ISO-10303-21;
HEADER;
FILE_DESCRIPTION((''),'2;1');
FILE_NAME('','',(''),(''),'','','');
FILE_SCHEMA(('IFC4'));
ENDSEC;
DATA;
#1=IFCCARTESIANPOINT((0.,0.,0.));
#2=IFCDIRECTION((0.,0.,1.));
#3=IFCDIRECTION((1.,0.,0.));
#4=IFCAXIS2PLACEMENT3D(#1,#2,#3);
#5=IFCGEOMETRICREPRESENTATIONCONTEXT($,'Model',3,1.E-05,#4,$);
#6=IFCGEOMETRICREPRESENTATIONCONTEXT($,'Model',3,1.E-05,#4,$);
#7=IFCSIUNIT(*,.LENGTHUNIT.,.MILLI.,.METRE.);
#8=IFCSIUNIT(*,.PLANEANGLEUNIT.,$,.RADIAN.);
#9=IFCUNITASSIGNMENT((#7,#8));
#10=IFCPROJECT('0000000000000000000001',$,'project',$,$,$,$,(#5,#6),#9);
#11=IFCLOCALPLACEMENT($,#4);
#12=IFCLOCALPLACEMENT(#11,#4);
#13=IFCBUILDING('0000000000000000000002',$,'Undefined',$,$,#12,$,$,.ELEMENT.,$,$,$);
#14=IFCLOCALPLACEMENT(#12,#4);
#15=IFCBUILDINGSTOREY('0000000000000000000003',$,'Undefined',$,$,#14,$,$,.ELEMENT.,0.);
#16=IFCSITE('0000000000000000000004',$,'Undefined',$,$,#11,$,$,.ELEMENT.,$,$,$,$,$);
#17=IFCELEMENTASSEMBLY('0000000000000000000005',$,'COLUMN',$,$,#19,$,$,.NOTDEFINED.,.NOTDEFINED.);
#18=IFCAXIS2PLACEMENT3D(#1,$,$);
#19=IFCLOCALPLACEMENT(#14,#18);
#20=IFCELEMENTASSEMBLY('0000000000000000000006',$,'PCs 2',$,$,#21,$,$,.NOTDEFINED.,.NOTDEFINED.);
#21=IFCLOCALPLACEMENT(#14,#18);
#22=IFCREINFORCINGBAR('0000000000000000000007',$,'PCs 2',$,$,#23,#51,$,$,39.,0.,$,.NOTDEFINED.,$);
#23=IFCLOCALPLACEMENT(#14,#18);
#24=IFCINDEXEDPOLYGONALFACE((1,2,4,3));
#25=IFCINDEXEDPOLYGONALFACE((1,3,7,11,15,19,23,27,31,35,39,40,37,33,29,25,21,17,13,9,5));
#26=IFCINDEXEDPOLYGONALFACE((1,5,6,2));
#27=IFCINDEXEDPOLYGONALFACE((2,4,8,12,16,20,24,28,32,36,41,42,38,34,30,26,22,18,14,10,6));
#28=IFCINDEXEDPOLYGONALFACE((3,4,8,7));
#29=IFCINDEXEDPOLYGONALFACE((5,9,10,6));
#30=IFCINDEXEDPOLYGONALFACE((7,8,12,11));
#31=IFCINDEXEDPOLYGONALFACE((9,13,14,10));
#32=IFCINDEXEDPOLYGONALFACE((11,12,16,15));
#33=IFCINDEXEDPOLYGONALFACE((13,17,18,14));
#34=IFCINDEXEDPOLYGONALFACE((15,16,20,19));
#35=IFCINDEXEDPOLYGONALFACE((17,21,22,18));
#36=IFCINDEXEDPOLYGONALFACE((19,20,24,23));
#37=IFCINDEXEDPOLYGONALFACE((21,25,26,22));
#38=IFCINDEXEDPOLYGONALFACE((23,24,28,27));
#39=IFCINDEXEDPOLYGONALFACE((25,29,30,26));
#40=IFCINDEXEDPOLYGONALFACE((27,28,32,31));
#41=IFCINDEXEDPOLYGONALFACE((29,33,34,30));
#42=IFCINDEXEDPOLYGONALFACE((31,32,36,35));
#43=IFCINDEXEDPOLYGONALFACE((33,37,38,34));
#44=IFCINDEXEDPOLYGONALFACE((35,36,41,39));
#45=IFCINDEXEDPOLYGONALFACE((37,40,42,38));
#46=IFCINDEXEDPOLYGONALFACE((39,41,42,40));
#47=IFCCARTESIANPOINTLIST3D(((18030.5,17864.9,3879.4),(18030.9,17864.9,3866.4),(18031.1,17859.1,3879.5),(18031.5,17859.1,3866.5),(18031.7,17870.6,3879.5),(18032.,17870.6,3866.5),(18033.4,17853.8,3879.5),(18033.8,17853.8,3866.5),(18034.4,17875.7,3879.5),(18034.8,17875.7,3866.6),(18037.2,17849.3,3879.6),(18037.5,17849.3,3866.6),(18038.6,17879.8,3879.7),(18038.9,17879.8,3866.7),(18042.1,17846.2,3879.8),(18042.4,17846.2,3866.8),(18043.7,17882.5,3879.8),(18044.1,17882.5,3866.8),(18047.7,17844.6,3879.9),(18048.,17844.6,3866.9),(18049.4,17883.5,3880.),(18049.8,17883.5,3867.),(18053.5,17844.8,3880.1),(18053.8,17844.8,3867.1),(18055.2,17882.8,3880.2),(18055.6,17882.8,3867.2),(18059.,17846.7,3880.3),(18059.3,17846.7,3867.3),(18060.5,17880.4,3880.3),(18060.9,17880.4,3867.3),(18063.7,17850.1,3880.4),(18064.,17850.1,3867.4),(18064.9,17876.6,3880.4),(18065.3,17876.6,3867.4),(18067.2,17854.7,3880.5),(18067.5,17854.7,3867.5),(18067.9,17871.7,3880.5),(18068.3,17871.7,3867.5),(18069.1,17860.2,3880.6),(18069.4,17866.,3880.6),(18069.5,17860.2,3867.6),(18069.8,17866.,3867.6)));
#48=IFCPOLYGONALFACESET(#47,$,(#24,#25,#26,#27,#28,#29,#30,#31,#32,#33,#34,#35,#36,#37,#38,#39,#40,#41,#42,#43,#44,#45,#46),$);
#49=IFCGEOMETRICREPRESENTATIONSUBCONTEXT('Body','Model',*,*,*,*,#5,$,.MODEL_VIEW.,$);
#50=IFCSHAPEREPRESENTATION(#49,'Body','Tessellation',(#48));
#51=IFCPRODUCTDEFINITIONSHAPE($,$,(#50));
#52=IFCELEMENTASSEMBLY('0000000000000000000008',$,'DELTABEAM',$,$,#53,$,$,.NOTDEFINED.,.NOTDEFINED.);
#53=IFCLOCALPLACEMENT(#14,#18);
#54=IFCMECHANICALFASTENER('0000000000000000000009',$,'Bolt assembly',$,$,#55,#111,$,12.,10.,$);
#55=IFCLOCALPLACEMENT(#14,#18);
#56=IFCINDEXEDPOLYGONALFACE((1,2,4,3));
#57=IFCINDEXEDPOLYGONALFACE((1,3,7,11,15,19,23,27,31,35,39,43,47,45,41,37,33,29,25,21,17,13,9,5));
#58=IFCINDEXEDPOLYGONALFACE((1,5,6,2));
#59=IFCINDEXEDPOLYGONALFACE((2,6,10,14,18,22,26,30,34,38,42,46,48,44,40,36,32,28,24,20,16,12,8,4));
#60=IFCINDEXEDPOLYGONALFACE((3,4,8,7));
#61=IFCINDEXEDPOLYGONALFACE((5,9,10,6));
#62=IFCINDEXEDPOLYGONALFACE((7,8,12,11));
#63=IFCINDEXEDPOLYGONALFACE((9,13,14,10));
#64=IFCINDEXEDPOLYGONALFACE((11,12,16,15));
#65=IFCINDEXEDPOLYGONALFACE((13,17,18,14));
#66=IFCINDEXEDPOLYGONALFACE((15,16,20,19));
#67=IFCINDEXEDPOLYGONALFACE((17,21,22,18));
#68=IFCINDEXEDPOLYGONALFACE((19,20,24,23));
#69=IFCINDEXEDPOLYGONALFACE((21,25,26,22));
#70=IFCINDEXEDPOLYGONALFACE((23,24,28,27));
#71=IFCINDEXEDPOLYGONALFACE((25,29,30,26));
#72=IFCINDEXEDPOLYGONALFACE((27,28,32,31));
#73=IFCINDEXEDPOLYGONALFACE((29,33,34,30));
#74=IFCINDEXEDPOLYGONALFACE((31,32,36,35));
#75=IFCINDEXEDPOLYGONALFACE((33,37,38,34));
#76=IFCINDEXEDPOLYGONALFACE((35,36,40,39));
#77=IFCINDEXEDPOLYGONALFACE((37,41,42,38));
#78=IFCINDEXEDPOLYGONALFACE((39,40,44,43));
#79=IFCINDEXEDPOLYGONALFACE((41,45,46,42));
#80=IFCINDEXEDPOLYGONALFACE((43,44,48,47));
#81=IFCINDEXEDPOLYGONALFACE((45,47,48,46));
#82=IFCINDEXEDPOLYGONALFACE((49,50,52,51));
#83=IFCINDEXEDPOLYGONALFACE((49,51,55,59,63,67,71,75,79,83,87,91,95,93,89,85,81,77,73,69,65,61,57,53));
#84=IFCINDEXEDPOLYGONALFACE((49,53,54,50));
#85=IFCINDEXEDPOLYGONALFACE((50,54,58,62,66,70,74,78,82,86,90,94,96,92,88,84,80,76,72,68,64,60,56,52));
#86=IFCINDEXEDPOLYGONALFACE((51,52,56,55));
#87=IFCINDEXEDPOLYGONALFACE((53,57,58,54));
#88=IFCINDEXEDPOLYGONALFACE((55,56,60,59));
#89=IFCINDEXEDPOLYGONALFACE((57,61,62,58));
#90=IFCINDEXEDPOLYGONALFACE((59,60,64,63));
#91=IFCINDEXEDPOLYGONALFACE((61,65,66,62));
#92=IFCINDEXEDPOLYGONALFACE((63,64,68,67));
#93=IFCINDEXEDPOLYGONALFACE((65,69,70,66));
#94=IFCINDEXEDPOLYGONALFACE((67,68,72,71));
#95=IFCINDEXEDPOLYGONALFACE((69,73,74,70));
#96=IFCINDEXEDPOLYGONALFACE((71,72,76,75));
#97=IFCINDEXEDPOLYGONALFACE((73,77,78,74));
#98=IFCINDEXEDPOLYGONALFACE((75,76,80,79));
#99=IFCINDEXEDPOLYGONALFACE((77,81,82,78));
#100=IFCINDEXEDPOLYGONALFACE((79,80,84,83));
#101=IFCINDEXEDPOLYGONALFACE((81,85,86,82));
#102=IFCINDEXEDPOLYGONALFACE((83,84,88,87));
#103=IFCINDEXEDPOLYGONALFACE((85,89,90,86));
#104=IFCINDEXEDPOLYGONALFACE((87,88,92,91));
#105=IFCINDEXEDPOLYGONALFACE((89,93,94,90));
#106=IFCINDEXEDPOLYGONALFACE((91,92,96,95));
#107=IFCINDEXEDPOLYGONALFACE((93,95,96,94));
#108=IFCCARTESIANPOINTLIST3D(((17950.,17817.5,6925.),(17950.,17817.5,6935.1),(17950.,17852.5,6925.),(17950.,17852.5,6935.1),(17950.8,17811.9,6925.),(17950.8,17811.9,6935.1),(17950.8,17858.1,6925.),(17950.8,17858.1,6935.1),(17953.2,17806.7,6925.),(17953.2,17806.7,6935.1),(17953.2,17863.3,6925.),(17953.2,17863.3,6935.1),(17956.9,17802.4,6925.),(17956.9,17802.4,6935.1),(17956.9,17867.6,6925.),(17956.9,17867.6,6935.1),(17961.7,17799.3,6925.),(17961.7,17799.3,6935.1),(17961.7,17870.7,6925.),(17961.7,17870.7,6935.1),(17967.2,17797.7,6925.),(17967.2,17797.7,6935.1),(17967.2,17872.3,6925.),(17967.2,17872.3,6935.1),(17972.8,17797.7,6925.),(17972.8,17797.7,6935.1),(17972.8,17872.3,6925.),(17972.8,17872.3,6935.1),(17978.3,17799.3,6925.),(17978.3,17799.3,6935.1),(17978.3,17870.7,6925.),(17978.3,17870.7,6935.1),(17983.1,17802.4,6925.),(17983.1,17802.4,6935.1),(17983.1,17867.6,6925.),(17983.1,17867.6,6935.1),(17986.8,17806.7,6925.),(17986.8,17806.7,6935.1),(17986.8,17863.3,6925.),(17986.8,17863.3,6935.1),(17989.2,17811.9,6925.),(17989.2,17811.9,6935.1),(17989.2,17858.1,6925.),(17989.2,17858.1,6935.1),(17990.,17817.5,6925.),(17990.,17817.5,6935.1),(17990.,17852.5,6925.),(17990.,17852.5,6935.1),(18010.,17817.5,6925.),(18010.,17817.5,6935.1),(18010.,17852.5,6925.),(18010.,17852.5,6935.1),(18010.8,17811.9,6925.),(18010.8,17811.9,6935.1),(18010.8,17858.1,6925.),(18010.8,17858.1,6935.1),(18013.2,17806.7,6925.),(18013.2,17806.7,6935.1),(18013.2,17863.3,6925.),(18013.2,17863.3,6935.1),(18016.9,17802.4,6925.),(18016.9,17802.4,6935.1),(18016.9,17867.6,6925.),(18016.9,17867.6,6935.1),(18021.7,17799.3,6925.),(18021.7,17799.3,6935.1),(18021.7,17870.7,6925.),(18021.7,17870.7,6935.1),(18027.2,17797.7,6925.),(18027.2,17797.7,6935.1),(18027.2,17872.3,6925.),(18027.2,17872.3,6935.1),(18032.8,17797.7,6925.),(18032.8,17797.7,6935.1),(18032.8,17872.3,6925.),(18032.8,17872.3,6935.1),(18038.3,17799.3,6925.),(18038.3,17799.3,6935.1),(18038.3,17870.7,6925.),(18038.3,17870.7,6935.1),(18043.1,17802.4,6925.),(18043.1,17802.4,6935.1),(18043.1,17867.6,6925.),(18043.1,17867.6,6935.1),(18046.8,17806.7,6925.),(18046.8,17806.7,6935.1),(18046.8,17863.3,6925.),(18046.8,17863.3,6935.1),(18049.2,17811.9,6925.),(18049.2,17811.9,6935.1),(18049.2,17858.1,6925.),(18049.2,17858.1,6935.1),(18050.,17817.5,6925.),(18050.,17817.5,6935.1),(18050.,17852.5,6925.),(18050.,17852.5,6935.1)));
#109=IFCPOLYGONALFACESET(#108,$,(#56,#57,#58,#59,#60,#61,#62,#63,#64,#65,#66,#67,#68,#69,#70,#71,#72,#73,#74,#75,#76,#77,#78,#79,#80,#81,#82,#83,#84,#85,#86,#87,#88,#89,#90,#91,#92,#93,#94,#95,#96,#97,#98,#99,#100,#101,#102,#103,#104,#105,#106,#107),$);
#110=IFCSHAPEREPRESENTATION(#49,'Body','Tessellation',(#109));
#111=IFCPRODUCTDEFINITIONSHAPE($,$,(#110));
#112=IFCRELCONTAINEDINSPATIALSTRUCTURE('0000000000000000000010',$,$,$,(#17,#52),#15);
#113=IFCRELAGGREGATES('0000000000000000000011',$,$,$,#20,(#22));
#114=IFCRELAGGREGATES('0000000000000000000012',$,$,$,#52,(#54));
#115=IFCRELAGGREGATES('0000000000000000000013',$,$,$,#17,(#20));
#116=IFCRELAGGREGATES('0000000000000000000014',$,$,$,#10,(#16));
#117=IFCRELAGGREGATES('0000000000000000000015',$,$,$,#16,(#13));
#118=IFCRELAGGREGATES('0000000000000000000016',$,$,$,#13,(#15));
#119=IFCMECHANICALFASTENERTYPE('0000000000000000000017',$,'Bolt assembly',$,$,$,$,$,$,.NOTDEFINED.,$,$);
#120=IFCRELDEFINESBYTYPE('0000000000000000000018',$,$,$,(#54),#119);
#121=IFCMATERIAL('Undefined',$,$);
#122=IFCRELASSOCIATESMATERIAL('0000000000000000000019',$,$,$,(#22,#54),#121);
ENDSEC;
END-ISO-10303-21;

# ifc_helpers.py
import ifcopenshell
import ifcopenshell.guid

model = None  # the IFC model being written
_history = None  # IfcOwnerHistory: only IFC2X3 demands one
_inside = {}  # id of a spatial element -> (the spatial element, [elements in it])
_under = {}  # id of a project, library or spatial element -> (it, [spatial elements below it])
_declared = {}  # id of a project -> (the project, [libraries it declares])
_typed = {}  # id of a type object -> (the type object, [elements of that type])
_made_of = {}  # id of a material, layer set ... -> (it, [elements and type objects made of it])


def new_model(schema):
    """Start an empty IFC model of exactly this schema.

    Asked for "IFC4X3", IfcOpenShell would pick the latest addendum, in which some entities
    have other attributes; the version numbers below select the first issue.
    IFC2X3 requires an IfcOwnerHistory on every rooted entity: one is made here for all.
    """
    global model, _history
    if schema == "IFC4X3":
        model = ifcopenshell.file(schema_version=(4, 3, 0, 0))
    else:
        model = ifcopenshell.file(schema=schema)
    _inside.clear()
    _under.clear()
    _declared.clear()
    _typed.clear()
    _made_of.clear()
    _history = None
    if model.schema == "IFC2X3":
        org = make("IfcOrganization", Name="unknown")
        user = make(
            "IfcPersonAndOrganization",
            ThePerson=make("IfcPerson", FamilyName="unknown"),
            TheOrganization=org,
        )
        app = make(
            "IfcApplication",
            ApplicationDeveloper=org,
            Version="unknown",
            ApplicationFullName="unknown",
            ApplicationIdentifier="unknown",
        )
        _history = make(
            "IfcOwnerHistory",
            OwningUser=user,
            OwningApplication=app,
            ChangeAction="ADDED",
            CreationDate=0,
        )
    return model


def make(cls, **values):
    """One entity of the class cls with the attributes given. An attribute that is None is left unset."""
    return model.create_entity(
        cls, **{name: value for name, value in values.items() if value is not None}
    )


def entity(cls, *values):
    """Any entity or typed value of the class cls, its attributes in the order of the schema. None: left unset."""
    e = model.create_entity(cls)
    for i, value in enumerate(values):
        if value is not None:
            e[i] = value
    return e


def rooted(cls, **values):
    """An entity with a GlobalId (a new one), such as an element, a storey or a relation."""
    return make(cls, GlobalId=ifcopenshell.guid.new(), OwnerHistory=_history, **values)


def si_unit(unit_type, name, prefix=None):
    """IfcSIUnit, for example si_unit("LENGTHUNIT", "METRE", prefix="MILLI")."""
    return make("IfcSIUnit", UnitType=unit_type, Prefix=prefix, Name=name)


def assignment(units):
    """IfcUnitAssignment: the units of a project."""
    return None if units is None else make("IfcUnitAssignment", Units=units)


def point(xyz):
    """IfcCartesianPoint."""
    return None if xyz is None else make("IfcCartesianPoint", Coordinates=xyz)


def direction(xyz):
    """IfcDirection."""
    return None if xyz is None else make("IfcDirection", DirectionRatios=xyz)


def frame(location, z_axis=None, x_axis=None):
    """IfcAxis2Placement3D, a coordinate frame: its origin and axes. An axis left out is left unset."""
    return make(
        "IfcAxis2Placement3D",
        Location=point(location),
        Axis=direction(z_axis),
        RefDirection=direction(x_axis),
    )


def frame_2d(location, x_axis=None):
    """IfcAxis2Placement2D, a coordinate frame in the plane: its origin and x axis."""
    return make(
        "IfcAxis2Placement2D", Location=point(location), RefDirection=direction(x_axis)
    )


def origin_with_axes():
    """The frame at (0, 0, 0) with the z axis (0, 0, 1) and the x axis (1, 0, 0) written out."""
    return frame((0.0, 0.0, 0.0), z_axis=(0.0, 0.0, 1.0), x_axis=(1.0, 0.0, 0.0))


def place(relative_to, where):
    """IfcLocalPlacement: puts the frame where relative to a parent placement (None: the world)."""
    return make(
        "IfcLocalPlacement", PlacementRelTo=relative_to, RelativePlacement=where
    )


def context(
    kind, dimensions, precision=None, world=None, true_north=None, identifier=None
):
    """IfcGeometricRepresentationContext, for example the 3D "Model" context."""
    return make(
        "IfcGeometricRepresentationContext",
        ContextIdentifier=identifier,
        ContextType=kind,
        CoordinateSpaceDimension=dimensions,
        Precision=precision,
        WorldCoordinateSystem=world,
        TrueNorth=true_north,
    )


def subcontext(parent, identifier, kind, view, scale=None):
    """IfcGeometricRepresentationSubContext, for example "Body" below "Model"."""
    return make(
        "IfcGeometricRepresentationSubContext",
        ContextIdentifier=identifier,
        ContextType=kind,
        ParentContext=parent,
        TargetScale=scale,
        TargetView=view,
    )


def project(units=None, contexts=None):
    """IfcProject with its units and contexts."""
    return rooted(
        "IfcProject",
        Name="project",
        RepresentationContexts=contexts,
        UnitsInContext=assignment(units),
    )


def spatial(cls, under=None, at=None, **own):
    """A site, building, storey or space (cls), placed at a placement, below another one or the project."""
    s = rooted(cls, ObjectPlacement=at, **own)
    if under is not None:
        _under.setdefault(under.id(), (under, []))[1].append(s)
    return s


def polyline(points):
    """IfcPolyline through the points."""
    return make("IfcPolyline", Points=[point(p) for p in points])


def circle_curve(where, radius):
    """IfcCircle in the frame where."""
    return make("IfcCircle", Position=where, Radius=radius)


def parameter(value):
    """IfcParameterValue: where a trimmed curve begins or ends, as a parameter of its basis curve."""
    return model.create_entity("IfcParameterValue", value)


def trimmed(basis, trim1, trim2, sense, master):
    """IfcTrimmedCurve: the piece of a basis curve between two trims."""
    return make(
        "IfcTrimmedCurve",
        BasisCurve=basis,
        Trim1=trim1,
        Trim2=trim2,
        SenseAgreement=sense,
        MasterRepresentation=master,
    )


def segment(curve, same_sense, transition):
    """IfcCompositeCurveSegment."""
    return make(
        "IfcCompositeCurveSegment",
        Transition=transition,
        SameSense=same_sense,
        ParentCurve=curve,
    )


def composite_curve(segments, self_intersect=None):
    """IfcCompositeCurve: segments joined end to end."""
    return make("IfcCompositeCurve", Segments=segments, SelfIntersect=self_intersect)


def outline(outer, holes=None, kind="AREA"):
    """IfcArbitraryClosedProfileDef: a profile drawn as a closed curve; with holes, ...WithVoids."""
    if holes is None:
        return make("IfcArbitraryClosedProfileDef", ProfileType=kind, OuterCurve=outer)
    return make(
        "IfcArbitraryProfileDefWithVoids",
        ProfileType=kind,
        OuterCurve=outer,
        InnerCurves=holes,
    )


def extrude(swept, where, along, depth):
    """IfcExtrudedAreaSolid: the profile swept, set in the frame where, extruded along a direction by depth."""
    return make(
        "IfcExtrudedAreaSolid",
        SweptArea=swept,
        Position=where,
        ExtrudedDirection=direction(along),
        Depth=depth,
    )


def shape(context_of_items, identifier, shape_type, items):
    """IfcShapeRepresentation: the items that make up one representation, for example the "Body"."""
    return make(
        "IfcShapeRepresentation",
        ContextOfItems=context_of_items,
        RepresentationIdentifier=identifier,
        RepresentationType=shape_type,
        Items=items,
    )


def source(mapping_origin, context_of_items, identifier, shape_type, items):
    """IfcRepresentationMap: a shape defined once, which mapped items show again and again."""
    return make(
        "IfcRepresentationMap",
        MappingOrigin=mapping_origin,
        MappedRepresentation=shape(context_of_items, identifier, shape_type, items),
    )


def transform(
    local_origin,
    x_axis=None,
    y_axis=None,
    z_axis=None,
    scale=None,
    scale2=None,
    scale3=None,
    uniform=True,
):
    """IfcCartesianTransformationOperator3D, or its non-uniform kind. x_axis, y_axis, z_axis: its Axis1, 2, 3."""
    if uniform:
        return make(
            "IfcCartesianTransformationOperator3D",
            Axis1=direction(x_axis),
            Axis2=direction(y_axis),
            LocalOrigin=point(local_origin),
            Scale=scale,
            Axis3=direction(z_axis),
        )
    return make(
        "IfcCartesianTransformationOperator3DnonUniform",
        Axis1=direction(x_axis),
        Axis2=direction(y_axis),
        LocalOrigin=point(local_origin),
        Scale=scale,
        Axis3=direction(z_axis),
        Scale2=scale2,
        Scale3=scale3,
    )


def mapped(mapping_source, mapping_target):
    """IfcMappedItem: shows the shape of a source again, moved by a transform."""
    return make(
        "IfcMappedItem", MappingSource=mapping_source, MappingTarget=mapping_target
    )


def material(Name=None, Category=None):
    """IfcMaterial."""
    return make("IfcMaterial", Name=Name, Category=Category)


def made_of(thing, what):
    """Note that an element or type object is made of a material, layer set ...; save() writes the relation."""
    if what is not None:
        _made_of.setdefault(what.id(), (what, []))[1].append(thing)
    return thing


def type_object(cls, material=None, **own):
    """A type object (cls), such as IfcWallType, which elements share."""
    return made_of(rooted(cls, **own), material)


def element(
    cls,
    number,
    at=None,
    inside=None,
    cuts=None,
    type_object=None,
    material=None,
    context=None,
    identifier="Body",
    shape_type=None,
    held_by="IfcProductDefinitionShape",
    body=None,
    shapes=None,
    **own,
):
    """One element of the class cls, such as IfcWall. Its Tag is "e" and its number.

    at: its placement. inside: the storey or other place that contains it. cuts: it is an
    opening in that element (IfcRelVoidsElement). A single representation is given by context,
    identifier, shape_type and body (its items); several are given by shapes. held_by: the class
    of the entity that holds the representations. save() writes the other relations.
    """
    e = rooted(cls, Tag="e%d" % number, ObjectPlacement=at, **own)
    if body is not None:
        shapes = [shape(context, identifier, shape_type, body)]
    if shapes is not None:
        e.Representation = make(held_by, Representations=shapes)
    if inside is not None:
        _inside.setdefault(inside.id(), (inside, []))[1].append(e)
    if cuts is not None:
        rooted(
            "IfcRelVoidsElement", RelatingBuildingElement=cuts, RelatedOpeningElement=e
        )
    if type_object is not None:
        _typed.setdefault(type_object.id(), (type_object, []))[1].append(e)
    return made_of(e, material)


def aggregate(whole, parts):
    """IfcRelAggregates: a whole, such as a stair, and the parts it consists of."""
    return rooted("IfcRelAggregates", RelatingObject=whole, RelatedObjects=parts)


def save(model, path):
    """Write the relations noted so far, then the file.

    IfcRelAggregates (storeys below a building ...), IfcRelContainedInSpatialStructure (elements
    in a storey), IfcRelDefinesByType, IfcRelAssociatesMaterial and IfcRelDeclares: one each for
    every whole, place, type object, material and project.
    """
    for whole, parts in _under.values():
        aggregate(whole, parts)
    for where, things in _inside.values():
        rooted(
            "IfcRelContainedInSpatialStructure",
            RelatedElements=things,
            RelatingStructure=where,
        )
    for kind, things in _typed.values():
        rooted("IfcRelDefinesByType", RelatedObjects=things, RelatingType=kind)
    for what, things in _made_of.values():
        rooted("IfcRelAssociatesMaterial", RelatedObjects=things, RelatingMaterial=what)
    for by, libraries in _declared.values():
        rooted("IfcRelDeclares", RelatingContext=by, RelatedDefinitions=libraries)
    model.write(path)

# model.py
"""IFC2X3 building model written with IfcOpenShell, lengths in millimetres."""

from ifc_helpers import new_model, entity, si_unit, frame, frame_2d, origin_with_axes, place, context, subcontext, project, spatial, polyline, circle_curve, parameter, trimmed, segment, composite_curve, outline, extrude, source, transform, mapped, material, type_object, element, aggregate, save


model = new_model("IFC2X3")

# Units and contexts
model_context_1 = context("Model", 3, precision=1e-05, world=origin_with_axes())
model_context_2 = context("Model", 3, precision=1e-05, world=origin_with_axes())
body_context = subcontext(model_context_1, "Body", "Model", "MODEL_VIEW")
ifc_project = project(units=[si_unit("LENGTHUNIT", "METRE", prefix="MILLI"), si_unit("PLANEANGLEUNIT", "RADIAN")], contexts=[model_context_1, model_context_2])

# Site, building, storey
site_placement = place(None, origin_with_axes())
site = spatial("IfcSite", under=ifc_project, at=site_placement, Name="Undefined", CompositionType="ELEMENT")
building_placement = place(site_placement, origin_with_axes())
building = spatial("IfcBuilding", under=site, at=building_placement, Name="Undefined", CompositionType="ELEMENT")
storey_placement = place(building_placement, origin_with_axes())
storey = spatial("IfcBuildingStorey", under=building, at=storey_placement, Name="Undefined", CompositionType="ELEMENT", Elevation=0.0)

# Element assembly
assembly_1_placement = place(storey_placement, origin_with_axes())
assembly_1 = element("IfcElementAssembly", 1, at=assembly_1_placement, inside=storey, Name="COLUMN", AssemblyPlace="NOTDEFINED", PredefinedType="NOTDEFINED")

# Element assembly
assembly_2_placement = place(assembly_1_placement, origin_with_axes())
assembly_2 = element("IfcElementAssembly", 2, at=assembly_2_placement, Name="PCs 2", AssemblyPlace="NOTDEFINED", PredefinedType="NOTDEFINED")

# Shared definitions
ifc_material_1 = material(Name="Undefined")
mechanical_fastener_type = type_object("IfcMechanicalFastenerType", Name="Bolt assembly")

# Reinforcing bar
shared_shape_1 = source(origin_with_axes(), body_context, "Body", "AdvancedSweptSolid", [
    entity("IfcSweptDiskSolid", entity("IfcTrimmedCurve", entity("IfcLine", entity("IfcCartesianPoint", [0.0, 0.0, 0.0]), entity("IfcVector", entity("IfcDirection", [1.0, 0.0, 0.0]), 1.0)), [entity("IfcParameterValue", 0.0)], [entity("IfcParameterValue", 13.0)], True, "PARAMETER"), 19.5, None, 0.0, 13.0),
])
reinforcing_bar_1_placement = place(assembly_2_placement, frame((18050.4, 17864.0, 3867.0), z_axis=(0.701084, -0.712786, 0.020417), x_axis=(-0.02911, 0.0, 0.999576)))
reinforcing_bar_1 = element("IfcReinforcingBar", 3, at=reinforcing_bar_1_placement, material=ifc_material_1, Name="PCs 2", BarRole="NOTDEFINED", CrossSectionArea=0.0, NominalDiameter=39.0, context=body_context, shape_type="MappedRepresentation", body=[
    mapped(shared_shape_1, transform((0.0, 0.0, 0.0))),
])
aggregate(assembly_2, [reinforcing_bar_1])

# Element assembly, mechanical fastener
assembly_3_placement = place(storey_placement, origin_with_axes())
assembly_3 = element("IfcElementAssembly", 4, at=assembly_3_placement, inside=storey, Name="DELTABEAM", AssemblyPlace="NOTDEFINED", PredefinedType="NOTDEFINED")
shared_shape_2 = source(origin_with_axes(), body_context, "Body", "SweptSolid", [
    extrude(outline(composite_curve([segment(polyline([(20.0, 17.5), (20.0, -17.5)]), True, "CONTINUOUS"), segment(trimmed(circle_curve(frame_2d((0.0, -17.5), x_axis=(1.0, 0.0)), 20.0), [parameter(0.0)], [parameter(3.141593)], False, "PARAMETER"), True, "CONTINUOUS"), segment(polyline([(-20.0, -17.5), (-20.0, 17.5)]), True, "CONTINUOUS"), segment(trimmed(circle_curve(frame_2d((0.0, 17.5), x_axis=(-1.0, 0.0)), 20.0), [parameter(0.0)], [parameter(3.141593)], False, "PARAMETER"), True, "DISCONTINUOUS")], self_intersect=False)), frame((0.0, -15.0, 0.0), z_axis=(0.0, 1.0, 0.0), x_axis=(1.0, 0.0, 0.0)), (0.0, 0.0, 1.0), 10.1),
])
mechanical_fastener_1_placement = place(assembly_3_placement, frame((18030.0, 17835.0, 6940.0), z_axis=(0.0, 1.0, 0.0), x_axis=(-1.0, 0.0, 0.0)))
mechanical_fastener_1 = element("IfcMechanicalFastener", 5, at=mechanical_fastener_1_placement, type_object=mechanical_fastener_type, material=ifc_material_1, Name="Bolt assembly", NominalDiameter=12.0, NominalLength=10.0, context=body_context, shape_type="MappedRepresentation", body=[
    mapped(shared_shape_2, transform((0.0, 0.0, 0.0))),
    mapped(shared_shape_2, transform((60.0, 0.0, 0.0))),
])
aggregate(assembly_3, [mechanical_fastener_1])

aggregate(assembly_1, [assembly_2])

save(model, "model.ifc")
